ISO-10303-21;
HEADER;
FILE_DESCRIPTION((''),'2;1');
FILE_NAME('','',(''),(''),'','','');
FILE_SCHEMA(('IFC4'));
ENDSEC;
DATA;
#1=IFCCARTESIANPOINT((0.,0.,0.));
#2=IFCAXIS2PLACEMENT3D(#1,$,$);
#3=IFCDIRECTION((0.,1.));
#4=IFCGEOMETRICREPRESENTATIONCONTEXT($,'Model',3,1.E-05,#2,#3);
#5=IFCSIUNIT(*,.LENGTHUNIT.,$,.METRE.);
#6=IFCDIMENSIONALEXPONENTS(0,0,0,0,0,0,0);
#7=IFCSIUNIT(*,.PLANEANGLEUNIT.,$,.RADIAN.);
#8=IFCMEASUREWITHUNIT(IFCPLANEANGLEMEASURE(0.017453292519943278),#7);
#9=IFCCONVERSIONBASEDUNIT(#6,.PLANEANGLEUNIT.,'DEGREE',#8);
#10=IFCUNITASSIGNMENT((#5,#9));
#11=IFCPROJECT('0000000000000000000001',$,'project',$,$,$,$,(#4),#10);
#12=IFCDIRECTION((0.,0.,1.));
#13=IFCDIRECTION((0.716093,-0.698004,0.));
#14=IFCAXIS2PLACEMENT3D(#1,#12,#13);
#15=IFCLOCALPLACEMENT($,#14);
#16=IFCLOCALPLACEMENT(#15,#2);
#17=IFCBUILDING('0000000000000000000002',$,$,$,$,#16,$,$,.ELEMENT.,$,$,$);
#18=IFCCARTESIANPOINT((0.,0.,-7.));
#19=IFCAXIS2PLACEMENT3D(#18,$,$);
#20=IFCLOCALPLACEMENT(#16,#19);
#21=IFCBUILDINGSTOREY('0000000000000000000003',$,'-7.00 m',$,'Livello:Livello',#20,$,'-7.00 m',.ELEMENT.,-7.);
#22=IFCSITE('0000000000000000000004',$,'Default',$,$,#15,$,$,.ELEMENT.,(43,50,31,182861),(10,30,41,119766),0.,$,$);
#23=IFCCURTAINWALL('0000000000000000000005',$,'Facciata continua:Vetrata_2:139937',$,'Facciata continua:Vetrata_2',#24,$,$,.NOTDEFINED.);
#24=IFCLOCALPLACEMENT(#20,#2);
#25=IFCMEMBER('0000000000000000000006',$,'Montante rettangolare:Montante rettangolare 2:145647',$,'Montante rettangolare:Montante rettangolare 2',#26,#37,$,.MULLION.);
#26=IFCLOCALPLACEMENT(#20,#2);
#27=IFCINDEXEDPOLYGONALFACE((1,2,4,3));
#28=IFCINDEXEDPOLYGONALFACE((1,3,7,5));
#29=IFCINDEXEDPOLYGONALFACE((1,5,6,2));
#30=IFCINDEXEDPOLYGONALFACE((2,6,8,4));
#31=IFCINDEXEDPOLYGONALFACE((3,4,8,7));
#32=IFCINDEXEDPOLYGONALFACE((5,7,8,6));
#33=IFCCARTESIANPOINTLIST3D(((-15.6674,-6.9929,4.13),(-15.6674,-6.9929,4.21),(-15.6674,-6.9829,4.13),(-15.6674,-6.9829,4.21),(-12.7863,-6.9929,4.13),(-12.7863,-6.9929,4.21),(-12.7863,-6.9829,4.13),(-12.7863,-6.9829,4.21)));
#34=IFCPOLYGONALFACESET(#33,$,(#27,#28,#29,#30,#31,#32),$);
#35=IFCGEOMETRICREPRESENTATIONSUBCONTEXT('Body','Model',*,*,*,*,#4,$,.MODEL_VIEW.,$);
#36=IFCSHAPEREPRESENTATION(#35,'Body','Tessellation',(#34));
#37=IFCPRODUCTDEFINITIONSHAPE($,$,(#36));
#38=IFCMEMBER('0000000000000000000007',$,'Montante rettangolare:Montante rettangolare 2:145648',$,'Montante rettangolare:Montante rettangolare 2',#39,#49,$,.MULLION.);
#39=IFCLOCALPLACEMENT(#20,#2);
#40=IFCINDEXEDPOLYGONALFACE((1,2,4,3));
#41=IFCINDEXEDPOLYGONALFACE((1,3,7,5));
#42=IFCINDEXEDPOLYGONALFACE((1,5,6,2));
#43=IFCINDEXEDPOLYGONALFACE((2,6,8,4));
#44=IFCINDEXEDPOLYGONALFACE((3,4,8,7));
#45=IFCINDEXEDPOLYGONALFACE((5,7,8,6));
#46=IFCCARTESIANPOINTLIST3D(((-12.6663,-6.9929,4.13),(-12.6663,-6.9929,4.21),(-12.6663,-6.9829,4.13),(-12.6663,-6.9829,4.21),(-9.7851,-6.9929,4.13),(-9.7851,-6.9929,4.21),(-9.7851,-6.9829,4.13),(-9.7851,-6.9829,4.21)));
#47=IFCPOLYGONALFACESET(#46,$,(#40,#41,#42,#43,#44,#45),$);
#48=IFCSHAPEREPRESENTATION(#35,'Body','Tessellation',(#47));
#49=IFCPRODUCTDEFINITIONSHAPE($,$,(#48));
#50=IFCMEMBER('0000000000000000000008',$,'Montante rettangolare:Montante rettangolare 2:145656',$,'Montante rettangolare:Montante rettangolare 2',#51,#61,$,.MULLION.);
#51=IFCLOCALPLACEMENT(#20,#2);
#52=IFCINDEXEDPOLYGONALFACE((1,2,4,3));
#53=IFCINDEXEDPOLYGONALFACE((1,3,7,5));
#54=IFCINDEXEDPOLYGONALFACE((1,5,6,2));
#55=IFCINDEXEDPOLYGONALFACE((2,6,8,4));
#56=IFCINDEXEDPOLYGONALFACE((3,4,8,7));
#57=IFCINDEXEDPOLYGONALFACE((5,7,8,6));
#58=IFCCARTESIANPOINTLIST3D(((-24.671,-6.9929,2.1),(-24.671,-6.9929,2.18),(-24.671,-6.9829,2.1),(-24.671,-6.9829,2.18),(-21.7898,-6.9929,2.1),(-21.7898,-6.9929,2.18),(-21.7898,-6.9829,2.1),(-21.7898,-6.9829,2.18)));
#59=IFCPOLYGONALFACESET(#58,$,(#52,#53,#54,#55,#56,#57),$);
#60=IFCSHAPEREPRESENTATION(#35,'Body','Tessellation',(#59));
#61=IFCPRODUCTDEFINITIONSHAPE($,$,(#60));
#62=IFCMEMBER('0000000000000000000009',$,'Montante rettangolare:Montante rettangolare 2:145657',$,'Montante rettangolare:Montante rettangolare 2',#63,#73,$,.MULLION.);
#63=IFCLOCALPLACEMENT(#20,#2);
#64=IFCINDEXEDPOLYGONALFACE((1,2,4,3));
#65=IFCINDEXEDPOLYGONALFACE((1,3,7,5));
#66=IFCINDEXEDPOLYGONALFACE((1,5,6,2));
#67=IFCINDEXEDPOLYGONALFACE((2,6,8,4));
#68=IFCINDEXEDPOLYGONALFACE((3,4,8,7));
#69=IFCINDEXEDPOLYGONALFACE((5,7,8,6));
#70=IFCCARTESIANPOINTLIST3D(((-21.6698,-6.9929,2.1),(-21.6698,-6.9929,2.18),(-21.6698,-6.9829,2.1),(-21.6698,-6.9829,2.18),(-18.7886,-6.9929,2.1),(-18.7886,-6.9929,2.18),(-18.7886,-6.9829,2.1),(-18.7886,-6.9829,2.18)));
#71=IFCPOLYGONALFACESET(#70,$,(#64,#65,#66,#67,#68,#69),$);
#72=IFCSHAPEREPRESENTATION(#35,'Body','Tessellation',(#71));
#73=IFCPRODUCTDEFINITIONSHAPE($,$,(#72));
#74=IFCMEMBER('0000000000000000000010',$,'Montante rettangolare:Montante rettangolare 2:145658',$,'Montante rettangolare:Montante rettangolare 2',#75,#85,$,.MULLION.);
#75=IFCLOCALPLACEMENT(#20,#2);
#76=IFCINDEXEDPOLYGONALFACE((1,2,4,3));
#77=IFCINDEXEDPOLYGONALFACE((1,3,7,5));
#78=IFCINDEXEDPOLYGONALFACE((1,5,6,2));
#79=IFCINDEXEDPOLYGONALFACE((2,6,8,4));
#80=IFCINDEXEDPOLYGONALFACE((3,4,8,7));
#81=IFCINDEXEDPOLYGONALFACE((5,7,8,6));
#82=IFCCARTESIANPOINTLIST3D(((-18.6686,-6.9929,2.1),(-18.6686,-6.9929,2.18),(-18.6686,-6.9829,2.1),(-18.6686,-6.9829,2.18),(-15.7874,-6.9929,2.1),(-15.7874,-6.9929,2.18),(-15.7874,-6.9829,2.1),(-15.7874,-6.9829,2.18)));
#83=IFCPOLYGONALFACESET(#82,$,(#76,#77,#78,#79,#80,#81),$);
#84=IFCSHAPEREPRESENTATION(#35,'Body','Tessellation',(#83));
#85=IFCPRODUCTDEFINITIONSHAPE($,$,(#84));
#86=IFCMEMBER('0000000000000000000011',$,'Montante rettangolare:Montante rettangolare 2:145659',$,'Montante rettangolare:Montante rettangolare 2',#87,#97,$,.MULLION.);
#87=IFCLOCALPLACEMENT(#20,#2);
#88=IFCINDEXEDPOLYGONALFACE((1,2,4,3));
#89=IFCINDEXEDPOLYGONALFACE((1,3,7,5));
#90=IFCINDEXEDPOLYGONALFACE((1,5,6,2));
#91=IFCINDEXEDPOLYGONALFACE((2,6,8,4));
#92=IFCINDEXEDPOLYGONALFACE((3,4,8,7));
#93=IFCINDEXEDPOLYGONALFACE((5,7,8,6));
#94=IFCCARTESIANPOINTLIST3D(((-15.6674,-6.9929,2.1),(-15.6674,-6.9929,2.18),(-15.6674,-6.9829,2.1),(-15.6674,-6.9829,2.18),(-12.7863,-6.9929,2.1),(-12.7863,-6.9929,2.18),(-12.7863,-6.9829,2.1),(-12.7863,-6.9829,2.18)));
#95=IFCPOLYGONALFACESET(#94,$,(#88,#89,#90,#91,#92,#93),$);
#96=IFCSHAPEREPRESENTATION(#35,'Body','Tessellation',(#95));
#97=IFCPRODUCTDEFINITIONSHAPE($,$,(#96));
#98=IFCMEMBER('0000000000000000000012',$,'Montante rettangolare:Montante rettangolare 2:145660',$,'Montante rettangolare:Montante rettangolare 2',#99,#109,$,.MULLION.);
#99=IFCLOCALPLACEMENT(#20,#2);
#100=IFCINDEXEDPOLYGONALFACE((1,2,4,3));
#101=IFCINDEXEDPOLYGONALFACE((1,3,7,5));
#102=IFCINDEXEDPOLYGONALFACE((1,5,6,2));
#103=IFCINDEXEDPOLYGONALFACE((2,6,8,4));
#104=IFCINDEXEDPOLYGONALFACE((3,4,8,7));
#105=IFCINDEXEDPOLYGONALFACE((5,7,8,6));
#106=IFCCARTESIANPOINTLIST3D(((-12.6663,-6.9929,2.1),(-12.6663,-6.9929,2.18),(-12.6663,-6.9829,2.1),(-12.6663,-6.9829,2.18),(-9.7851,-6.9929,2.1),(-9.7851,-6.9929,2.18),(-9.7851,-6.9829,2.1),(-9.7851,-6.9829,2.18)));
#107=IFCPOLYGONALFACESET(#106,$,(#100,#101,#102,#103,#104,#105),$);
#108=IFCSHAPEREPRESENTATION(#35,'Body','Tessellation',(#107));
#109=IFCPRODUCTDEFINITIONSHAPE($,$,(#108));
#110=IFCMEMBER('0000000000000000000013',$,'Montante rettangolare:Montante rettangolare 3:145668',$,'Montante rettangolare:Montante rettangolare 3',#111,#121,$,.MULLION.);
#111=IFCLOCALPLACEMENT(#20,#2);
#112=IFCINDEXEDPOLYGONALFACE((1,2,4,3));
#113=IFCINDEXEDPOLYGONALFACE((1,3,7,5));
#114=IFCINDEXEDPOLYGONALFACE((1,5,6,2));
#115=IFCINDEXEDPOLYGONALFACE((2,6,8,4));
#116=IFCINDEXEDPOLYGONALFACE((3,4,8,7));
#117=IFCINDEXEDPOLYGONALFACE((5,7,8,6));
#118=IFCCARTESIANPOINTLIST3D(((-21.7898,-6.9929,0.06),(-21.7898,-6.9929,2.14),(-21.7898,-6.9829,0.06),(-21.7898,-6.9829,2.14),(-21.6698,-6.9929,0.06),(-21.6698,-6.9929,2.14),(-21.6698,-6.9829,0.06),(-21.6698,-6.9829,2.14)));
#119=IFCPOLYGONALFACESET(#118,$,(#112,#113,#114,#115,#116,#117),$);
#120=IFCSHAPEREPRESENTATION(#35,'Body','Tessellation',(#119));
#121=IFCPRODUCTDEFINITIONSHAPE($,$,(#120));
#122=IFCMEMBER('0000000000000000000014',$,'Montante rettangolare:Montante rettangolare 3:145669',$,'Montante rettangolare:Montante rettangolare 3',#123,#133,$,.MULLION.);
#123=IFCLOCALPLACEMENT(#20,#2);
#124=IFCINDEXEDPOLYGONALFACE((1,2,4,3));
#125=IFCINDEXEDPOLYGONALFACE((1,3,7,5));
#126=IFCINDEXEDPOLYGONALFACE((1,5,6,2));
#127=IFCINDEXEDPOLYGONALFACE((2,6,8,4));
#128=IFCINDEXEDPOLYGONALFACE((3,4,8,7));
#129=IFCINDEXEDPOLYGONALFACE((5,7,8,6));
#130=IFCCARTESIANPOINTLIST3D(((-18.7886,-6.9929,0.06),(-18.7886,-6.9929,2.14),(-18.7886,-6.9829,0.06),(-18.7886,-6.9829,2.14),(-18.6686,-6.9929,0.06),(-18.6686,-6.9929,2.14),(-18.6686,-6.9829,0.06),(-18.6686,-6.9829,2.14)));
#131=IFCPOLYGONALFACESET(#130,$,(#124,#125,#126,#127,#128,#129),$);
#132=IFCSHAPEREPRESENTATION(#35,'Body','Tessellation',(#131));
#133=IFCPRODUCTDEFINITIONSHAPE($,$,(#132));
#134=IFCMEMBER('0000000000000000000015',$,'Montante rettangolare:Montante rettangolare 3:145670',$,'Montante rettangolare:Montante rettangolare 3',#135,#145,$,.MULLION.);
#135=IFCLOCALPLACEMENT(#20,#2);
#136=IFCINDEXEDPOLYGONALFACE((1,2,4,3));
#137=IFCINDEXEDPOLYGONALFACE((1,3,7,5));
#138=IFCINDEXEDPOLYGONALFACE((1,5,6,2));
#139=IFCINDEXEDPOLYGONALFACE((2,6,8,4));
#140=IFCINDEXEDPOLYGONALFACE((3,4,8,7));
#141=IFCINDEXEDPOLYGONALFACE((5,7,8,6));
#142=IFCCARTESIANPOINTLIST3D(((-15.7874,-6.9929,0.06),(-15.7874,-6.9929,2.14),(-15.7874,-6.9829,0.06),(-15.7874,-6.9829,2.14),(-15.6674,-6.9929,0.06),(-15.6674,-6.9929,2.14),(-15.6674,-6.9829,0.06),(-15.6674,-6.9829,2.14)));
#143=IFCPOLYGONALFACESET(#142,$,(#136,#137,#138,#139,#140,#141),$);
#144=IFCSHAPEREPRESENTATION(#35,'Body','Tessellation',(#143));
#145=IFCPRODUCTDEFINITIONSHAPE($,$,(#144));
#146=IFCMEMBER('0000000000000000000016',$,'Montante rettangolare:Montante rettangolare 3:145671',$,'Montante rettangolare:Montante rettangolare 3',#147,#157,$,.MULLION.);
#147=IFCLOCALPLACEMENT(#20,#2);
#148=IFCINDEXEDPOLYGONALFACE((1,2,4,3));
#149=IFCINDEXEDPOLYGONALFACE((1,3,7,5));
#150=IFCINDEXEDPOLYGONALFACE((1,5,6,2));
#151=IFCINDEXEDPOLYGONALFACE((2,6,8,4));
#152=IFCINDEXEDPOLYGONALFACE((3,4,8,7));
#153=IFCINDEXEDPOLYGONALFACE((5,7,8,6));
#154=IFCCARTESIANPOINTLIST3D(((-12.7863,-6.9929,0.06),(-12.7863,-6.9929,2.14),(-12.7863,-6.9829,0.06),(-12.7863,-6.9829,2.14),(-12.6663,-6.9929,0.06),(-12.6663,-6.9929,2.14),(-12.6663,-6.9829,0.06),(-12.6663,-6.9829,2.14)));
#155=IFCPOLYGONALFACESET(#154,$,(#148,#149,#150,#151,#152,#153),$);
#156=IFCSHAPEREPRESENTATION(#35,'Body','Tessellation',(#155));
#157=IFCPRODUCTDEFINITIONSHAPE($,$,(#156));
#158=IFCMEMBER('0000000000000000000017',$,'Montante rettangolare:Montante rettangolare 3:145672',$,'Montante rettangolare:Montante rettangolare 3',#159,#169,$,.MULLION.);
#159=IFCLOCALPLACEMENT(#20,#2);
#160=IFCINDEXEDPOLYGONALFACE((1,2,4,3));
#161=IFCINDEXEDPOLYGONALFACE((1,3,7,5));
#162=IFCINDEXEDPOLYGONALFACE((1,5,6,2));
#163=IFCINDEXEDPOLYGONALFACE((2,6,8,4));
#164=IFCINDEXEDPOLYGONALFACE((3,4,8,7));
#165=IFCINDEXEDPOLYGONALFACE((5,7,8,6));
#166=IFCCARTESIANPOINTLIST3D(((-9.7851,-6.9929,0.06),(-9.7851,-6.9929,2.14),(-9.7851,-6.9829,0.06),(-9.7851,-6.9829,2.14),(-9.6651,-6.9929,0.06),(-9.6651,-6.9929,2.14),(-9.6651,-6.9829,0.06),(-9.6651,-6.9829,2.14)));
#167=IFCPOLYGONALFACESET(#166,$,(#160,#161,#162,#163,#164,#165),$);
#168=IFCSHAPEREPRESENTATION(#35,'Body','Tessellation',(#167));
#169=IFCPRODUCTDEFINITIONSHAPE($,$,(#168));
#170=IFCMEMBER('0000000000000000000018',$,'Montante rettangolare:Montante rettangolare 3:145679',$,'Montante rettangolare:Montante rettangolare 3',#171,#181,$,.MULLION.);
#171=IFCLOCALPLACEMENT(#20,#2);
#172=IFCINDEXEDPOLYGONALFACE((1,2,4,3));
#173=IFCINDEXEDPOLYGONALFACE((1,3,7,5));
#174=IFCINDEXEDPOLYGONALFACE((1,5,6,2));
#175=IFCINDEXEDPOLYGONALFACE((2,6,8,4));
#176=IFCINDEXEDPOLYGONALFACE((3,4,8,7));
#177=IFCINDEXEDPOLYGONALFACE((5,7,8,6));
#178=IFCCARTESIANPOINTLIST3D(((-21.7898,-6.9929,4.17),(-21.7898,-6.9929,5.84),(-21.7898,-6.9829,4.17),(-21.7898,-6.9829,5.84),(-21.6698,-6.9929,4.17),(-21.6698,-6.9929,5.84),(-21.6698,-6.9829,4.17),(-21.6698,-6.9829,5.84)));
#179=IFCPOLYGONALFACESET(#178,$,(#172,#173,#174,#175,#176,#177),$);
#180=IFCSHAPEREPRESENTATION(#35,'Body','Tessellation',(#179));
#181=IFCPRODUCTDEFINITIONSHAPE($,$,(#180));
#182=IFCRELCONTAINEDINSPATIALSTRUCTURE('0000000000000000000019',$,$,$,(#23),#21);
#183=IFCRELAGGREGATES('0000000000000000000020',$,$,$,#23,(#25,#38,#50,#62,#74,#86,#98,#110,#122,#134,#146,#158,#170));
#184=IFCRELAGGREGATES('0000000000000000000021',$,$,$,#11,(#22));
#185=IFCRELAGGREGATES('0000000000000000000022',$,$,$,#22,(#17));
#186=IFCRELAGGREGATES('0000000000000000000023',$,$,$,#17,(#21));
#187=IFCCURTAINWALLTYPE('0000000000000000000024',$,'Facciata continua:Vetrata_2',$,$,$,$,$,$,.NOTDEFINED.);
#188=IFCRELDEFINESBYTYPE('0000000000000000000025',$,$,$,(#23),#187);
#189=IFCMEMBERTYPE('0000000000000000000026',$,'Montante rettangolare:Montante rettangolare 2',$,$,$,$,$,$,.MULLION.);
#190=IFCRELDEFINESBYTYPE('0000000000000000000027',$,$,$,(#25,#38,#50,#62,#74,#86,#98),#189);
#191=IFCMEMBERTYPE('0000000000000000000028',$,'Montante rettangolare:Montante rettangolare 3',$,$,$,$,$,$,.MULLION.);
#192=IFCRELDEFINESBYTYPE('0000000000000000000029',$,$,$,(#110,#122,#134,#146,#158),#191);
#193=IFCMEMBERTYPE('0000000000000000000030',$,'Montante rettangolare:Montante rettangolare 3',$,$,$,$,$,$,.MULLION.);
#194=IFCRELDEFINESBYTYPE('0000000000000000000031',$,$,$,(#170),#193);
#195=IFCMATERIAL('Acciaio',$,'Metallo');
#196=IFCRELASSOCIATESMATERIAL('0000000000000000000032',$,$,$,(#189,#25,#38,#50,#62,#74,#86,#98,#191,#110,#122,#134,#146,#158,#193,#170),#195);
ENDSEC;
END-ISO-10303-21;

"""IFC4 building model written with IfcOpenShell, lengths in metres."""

from ifc_helpers import new_model, entity, si_unit, converted_unit, direction, frame, origin, place, context, subcontext, project, spatial, indexed_curve, outline, extrude, source, transform, mapped, material, type_object, type_shapes, element, aggregate, save


model = new_model("IFC4")

# Units and contexts
model_context = context("Model", 3, precision=1e-05, world=origin(), true_north=direction((0.0, 1.0)))
body_context = subcontext(model_context, "Body", "Model", "MODEL_VIEW")
ifc_project = project(units=[si_unit("LENGTHUNIT", "METRE"), converted_unit("PLANEANGLEUNIT", "DEGREE", entity("IfcPlaneAngleMeasure", 0.017453292519943278), si_unit("PLANEANGLEUNIT", "RADIAN"), dimensions=[0, 0, 0, 0, 0, 0, 0])], contexts=[model_context])

# Site, building, storey
site_placement = place(None, frame((0.0, 0.0, 0.0), z_axis=(0.0, 0.0, 1.0), x_axis=(0.716093, -0.698004, 0.0)))
site = spatial("IfcSite", under=ifc_project, at=site_placement, Name="Default", CompositionType="ELEMENT", RefLatitude=(43, 50, 31, 182861), RefLongitude=(10, 30, 41, 119766), RefElevation=0.0)
building_placement = place(site_placement, origin())
building = spatial("IfcBuilding", under=site, at=building_placement, CompositionType="ELEMENT")
storey_placement = place(building_placement, frame((0.0, 0.0, -7.0)))
storey = spatial("IfcBuildingStorey", under=building, at=storey_placement, Name="-7.00 m", ObjectType="Livello:Livello", LongName="-7.00 m", CompositionType="ELEMENT", Elevation=-7.0)

# Curtain wall, members
curtain_wall_type = type_object("IfcCurtainWallType", Name="Facciata continua:Vetrata_2", PredefinedType="NOTDEFINED")
curtain_wall_placement = place(storey_placement, frame((0.0, 0.0, 7.0)))
curtain_wall = element("IfcCurtainWall", 1, at=curtain_wall_placement, inside=storey, type_object=curtain_wall_type, Name="Facciata continua:Vetrata_2:139937", ObjectType="Facciata continua:Vetrata_2", PredefinedType="NOTDEFINED")
ifc_material = material(Name="Acciaio", Category="Metallo")
member_type_1 = type_object("IfcMemberType", Name="Montante rettangolare:Montante rettangolare 2", PredefinedType="MULLION", material=ifc_material)
shared_shape_1 = source(origin(), body_context, "Body", "SweptSolid", [
    extrude(outline(indexed_curve([(-0.04, -0.005), (0.04, -0.005), (0.04, 0.005), (-0.04, 0.005), (-0.04, -0.005)], self_intersect=False)), frame((0.0, 0.01, -2.8812), z_axis=(0.0, 0.0, 1.0), x_axis=(-1.0, 0.0, 0.0)), (0.0, 0.0, 1.0), 2.8812),
])
type_shapes(member_type_1, [shared_shape_1])
member_1_placement = place(curtain_wall_placement, frame((-12.7863, -6.9779, -2.83), z_axis=(1.0, 0.0, 0.0), x_axis=(0.0, 0.0, 1.0)))
member_1 = element("IfcMember", 2, at=member_1_placement, type_object=member_type_1, material=ifc_material, Name="Montante rettangolare:Montante rettangolare 2:145647", ObjectType="Montante rettangolare:Montante rettangolare 2", PredefinedType="MULLION", context=body_context, shape_type="MappedRepresentation", body=[
    mapped(shared_shape_1, transform((0.0, 0.0, 0.0), scale=1.0)),
])
member_2_placement = place(curtain_wall_placement, frame((-9.7851, -6.9779, -2.83), z_axis=(1.0, 0.0, 0.0), x_axis=(0.0, 0.0, 1.0)))
member_2 = element("IfcMember", 3, at=member_2_placement, type_object=member_type_1, material=ifc_material, Name="Montante rettangolare:Montante rettangolare 2:145648", ObjectType="Montante rettangolare:Montante rettangolare 2", PredefinedType="MULLION", context=body_context, shape_type="MappedRepresentation", body=[
    mapped(shared_shape_1, transform((0.0, 0.0, 0.0), scale=1.0)),
])
member_3_placement = place(curtain_wall_placement, frame((-21.7898, -6.9779, -4.86), z_axis=(1.0, 0.0, 0.0), x_axis=(0.0, 0.0, 1.0)))
member_3 = element("IfcMember", 4, at=member_3_placement, type_object=member_type_1, material=ifc_material, Name="Montante rettangolare:Montante rettangolare 2:145656", ObjectType="Montante rettangolare:Montante rettangolare 2", PredefinedType="MULLION", context=body_context, shape_type="MappedRepresentation", body=[
    mapped(shared_shape_1, transform((0.0, 0.0, 0.0), scale=1.0)),
])
member_4_placement = place(curtain_wall_placement, frame((-18.7886, -6.9779, -4.86), z_axis=(1.0, 0.0, 0.0), x_axis=(0.0, 0.0, 1.0)))
member_4 = element("IfcMember", 5, at=member_4_placement, type_object=member_type_1, material=ifc_material, Name="Montante rettangolare:Montante rettangolare 2:145657", ObjectType="Montante rettangolare:Montante rettangolare 2", PredefinedType="MULLION", context=body_context, shape_type="MappedRepresentation", body=[
    mapped(shared_shape_1, transform((0.0, 0.0, 0.0), scale=1.0)),
])
member_5_placement = place(curtain_wall_placement, frame((-15.7874, -6.9779, -4.86), z_axis=(1.0, 0.0, 0.0), x_axis=(0.0, 0.0, 1.0)))
member_5 = element("IfcMember", 6, at=member_5_placement, type_object=member_type_1, material=ifc_material, Name="Montante rettangolare:Montante rettangolare 2:145658", ObjectType="Montante rettangolare:Montante rettangolare 2", PredefinedType="MULLION", context=body_context, shape_type="MappedRepresentation", body=[
    mapped(shared_shape_1, transform((0.0, 0.0, 0.0), scale=1.0)),
])
member_6_placement = place(curtain_wall_placement, frame((-12.7863, -6.9779, -4.86), z_axis=(1.0, 0.0, 0.0), x_axis=(0.0, 0.0, 1.0)))
member_6 = element("IfcMember", 7, at=member_6_placement, type_object=member_type_1, material=ifc_material, Name="Montante rettangolare:Montante rettangolare 2:145659", ObjectType="Montante rettangolare:Montante rettangolare 2", PredefinedType="MULLION", context=body_context, shape_type="MappedRepresentation", body=[
    mapped(shared_shape_1, transform((0.0, 0.0, 0.0), scale=1.0)),
])
member_7_placement = place(curtain_wall_placement, frame((-9.7851, -6.9779, -4.86), z_axis=(1.0, 0.0, 0.0), x_axis=(0.0, 0.0, 1.0)))
member_7 = element("IfcMember", 8, at=member_7_placement, type_object=member_type_1, material=ifc_material, Name="Montante rettangolare:Montante rettangolare 2:145660", ObjectType="Montante rettangolare:Montante rettangolare 2", PredefinedType="MULLION", context=body_context, shape_type="MappedRepresentation", body=[
    mapped(shared_shape_1, transform((0.0, 0.0, 0.0), scale=1.0)),
])
member_type_2 = type_object("IfcMemberType", Name="Montante rettangolare:Montante rettangolare 3", PredefinedType="MULLION", material=ifc_material)
shared_shape_2 = source(origin(), body_context, "Body", "SweptSolid", [
    extrude(outline(indexed_curve([(-0.06, -0.005), (0.06, -0.005), (0.06, 0.005), (-0.06, 0.005), (-0.06, -0.005)], self_intersect=False)), frame((0.0, 0.01, -2.08), z_axis=(0.0, 0.0, 1.0), x_axis=(-1.0, 0.0, 0.0)), (0.0, 0.0, 1.0), 2.08),
])
type_shapes(member_type_2, [shared_shape_2])
member_8_placement = place(curtain_wall_placement, frame((-21.7298, -6.9779, -6.94), z_axis=(0.0, 0.0, -1.0), x_axis=(1.0, 0.0, 0.0)))
member_8 = element("IfcMember", 9, at=member_8_placement, type_object=member_type_2, material=ifc_material, Name="Montante rettangolare:Montante rettangolare 3:145668", ObjectType="Montante rettangolare:Montante rettangolare 3", PredefinedType="MULLION", context=body_context, shape_type="MappedRepresentation", body=[
    mapped(shared_shape_2, transform((0.0, 0.0, 0.0), scale=1.0)),
])
member_9_placement = place(curtain_wall_placement, frame((-18.7286, -6.9779, -6.94), z_axis=(0.0, 0.0, -1.0), x_axis=(1.0, 0.0, 0.0)))
member_9 = element("IfcMember", 10, at=member_9_placement, type_object=member_type_2, material=ifc_material, Name="Montante rettangolare:Montante rettangolare 3:145669", ObjectType="Montante rettangolare:Montante rettangolare 3", PredefinedType="MULLION", context=body_context, shape_type="MappedRepresentation", body=[
    mapped(shared_shape_2, transform((0.0, 0.0, 0.0), scale=1.0)),
])
member_10_placement = place(curtain_wall_placement, frame((-15.7274, -6.9779, -6.94), z_axis=(0.0, 0.0, -1.0), x_axis=(1.0, 0.0, 0.0)))
member_10 = element("IfcMember", 11, at=member_10_placement, type_object=member_type_2, material=ifc_material, Name="Montante rettangolare:Montante rettangolare 3:145670", ObjectType="Montante rettangolare:Montante rettangolare 3", PredefinedType="MULLION", context=body_context, shape_type="MappedRepresentation", body=[
    mapped(shared_shape_2, transform((0.0, 0.0, 0.0), scale=1.0)),
])
member_11_placement = place(curtain_wall_placement, frame((-12.7263, -6.9779, -6.94), z_axis=(0.0, 0.0, -1.0), x_axis=(1.0, 0.0, 0.0)))
member_11 = element("IfcMember", 12, at=member_11_placement, type_object=member_type_2, material=ifc_material, Name="Montante rettangolare:Montante rettangolare 3:145671", ObjectType="Montante rettangolare:Montante rettangolare 3", PredefinedType="MULLION", context=body_context, shape_type="MappedRepresentation", body=[
    mapped(shared_shape_2, transform((0.0, 0.0, 0.0), scale=1.0)),
])
member_12_placement = place(curtain_wall_placement, frame((-9.7251, -6.9779, -6.94), z_axis=(0.0, 0.0, -1.0), x_axis=(1.0, 0.0, 0.0)))
member_12 = element("IfcMember", 13, at=member_12_placement, type_object=member_type_2, material=ifc_material, Name="Montante rettangolare:Montante rettangolare 3:145672", ObjectType="Montante rettangolare:Montante rettangolare 3", PredefinedType="MULLION", context=body_context, shape_type="MappedRepresentation", body=[
    mapped(shared_shape_2, transform((0.0, 0.0, 0.0), scale=1.0)),
])
member_type_3 = type_object("IfcMemberType", Name="Montante rettangolare:Montante rettangolare 3", PredefinedType="MULLION", material=ifc_material)
shared_shape_3 = source(origin(), body_context, "Body", "SweptSolid", [
    extrude(outline(indexed_curve([(-0.06, -0.005), (0.06, -0.005), (0.06, 0.005), (-0.06, 0.005), (-0.06, -0.005)], self_intersect=False)), frame((0.0, 0.01, -1.67), z_axis=(0.0, 0.0, 1.0), x_axis=(-1.0, 0.0, 0.0)), (0.0, 0.0, 1.0), 1.67),
])
type_shapes(member_type_3, [shared_shape_3])
member_13_placement = place(curtain_wall_placement, frame((-21.7298, -6.9779, -2.83), z_axis=(0.0, 0.0, -1.0), x_axis=(1.0, 0.0, 0.0)))
member_13 = element("IfcMember", 14, at=member_13_placement, type_object=member_type_3, material=ifc_material, Name="Montante rettangolare:Montante rettangolare 3:145679", ObjectType="Montante rettangolare:Montante rettangolare 3", PredefinedType="MULLION", context=body_context, shape_type="MappedRepresentation", body=[
    mapped(shared_shape_3, transform((0.0, 0.0, 0.0), scale=1.0)),
])
aggregate(curtain_wall, [member_1, member_2, member_3, member_4, member_5, member_6, member_7, member_8, member_9, member_10, member_11, member_12, member_13])

save(model, "model.ifc")
